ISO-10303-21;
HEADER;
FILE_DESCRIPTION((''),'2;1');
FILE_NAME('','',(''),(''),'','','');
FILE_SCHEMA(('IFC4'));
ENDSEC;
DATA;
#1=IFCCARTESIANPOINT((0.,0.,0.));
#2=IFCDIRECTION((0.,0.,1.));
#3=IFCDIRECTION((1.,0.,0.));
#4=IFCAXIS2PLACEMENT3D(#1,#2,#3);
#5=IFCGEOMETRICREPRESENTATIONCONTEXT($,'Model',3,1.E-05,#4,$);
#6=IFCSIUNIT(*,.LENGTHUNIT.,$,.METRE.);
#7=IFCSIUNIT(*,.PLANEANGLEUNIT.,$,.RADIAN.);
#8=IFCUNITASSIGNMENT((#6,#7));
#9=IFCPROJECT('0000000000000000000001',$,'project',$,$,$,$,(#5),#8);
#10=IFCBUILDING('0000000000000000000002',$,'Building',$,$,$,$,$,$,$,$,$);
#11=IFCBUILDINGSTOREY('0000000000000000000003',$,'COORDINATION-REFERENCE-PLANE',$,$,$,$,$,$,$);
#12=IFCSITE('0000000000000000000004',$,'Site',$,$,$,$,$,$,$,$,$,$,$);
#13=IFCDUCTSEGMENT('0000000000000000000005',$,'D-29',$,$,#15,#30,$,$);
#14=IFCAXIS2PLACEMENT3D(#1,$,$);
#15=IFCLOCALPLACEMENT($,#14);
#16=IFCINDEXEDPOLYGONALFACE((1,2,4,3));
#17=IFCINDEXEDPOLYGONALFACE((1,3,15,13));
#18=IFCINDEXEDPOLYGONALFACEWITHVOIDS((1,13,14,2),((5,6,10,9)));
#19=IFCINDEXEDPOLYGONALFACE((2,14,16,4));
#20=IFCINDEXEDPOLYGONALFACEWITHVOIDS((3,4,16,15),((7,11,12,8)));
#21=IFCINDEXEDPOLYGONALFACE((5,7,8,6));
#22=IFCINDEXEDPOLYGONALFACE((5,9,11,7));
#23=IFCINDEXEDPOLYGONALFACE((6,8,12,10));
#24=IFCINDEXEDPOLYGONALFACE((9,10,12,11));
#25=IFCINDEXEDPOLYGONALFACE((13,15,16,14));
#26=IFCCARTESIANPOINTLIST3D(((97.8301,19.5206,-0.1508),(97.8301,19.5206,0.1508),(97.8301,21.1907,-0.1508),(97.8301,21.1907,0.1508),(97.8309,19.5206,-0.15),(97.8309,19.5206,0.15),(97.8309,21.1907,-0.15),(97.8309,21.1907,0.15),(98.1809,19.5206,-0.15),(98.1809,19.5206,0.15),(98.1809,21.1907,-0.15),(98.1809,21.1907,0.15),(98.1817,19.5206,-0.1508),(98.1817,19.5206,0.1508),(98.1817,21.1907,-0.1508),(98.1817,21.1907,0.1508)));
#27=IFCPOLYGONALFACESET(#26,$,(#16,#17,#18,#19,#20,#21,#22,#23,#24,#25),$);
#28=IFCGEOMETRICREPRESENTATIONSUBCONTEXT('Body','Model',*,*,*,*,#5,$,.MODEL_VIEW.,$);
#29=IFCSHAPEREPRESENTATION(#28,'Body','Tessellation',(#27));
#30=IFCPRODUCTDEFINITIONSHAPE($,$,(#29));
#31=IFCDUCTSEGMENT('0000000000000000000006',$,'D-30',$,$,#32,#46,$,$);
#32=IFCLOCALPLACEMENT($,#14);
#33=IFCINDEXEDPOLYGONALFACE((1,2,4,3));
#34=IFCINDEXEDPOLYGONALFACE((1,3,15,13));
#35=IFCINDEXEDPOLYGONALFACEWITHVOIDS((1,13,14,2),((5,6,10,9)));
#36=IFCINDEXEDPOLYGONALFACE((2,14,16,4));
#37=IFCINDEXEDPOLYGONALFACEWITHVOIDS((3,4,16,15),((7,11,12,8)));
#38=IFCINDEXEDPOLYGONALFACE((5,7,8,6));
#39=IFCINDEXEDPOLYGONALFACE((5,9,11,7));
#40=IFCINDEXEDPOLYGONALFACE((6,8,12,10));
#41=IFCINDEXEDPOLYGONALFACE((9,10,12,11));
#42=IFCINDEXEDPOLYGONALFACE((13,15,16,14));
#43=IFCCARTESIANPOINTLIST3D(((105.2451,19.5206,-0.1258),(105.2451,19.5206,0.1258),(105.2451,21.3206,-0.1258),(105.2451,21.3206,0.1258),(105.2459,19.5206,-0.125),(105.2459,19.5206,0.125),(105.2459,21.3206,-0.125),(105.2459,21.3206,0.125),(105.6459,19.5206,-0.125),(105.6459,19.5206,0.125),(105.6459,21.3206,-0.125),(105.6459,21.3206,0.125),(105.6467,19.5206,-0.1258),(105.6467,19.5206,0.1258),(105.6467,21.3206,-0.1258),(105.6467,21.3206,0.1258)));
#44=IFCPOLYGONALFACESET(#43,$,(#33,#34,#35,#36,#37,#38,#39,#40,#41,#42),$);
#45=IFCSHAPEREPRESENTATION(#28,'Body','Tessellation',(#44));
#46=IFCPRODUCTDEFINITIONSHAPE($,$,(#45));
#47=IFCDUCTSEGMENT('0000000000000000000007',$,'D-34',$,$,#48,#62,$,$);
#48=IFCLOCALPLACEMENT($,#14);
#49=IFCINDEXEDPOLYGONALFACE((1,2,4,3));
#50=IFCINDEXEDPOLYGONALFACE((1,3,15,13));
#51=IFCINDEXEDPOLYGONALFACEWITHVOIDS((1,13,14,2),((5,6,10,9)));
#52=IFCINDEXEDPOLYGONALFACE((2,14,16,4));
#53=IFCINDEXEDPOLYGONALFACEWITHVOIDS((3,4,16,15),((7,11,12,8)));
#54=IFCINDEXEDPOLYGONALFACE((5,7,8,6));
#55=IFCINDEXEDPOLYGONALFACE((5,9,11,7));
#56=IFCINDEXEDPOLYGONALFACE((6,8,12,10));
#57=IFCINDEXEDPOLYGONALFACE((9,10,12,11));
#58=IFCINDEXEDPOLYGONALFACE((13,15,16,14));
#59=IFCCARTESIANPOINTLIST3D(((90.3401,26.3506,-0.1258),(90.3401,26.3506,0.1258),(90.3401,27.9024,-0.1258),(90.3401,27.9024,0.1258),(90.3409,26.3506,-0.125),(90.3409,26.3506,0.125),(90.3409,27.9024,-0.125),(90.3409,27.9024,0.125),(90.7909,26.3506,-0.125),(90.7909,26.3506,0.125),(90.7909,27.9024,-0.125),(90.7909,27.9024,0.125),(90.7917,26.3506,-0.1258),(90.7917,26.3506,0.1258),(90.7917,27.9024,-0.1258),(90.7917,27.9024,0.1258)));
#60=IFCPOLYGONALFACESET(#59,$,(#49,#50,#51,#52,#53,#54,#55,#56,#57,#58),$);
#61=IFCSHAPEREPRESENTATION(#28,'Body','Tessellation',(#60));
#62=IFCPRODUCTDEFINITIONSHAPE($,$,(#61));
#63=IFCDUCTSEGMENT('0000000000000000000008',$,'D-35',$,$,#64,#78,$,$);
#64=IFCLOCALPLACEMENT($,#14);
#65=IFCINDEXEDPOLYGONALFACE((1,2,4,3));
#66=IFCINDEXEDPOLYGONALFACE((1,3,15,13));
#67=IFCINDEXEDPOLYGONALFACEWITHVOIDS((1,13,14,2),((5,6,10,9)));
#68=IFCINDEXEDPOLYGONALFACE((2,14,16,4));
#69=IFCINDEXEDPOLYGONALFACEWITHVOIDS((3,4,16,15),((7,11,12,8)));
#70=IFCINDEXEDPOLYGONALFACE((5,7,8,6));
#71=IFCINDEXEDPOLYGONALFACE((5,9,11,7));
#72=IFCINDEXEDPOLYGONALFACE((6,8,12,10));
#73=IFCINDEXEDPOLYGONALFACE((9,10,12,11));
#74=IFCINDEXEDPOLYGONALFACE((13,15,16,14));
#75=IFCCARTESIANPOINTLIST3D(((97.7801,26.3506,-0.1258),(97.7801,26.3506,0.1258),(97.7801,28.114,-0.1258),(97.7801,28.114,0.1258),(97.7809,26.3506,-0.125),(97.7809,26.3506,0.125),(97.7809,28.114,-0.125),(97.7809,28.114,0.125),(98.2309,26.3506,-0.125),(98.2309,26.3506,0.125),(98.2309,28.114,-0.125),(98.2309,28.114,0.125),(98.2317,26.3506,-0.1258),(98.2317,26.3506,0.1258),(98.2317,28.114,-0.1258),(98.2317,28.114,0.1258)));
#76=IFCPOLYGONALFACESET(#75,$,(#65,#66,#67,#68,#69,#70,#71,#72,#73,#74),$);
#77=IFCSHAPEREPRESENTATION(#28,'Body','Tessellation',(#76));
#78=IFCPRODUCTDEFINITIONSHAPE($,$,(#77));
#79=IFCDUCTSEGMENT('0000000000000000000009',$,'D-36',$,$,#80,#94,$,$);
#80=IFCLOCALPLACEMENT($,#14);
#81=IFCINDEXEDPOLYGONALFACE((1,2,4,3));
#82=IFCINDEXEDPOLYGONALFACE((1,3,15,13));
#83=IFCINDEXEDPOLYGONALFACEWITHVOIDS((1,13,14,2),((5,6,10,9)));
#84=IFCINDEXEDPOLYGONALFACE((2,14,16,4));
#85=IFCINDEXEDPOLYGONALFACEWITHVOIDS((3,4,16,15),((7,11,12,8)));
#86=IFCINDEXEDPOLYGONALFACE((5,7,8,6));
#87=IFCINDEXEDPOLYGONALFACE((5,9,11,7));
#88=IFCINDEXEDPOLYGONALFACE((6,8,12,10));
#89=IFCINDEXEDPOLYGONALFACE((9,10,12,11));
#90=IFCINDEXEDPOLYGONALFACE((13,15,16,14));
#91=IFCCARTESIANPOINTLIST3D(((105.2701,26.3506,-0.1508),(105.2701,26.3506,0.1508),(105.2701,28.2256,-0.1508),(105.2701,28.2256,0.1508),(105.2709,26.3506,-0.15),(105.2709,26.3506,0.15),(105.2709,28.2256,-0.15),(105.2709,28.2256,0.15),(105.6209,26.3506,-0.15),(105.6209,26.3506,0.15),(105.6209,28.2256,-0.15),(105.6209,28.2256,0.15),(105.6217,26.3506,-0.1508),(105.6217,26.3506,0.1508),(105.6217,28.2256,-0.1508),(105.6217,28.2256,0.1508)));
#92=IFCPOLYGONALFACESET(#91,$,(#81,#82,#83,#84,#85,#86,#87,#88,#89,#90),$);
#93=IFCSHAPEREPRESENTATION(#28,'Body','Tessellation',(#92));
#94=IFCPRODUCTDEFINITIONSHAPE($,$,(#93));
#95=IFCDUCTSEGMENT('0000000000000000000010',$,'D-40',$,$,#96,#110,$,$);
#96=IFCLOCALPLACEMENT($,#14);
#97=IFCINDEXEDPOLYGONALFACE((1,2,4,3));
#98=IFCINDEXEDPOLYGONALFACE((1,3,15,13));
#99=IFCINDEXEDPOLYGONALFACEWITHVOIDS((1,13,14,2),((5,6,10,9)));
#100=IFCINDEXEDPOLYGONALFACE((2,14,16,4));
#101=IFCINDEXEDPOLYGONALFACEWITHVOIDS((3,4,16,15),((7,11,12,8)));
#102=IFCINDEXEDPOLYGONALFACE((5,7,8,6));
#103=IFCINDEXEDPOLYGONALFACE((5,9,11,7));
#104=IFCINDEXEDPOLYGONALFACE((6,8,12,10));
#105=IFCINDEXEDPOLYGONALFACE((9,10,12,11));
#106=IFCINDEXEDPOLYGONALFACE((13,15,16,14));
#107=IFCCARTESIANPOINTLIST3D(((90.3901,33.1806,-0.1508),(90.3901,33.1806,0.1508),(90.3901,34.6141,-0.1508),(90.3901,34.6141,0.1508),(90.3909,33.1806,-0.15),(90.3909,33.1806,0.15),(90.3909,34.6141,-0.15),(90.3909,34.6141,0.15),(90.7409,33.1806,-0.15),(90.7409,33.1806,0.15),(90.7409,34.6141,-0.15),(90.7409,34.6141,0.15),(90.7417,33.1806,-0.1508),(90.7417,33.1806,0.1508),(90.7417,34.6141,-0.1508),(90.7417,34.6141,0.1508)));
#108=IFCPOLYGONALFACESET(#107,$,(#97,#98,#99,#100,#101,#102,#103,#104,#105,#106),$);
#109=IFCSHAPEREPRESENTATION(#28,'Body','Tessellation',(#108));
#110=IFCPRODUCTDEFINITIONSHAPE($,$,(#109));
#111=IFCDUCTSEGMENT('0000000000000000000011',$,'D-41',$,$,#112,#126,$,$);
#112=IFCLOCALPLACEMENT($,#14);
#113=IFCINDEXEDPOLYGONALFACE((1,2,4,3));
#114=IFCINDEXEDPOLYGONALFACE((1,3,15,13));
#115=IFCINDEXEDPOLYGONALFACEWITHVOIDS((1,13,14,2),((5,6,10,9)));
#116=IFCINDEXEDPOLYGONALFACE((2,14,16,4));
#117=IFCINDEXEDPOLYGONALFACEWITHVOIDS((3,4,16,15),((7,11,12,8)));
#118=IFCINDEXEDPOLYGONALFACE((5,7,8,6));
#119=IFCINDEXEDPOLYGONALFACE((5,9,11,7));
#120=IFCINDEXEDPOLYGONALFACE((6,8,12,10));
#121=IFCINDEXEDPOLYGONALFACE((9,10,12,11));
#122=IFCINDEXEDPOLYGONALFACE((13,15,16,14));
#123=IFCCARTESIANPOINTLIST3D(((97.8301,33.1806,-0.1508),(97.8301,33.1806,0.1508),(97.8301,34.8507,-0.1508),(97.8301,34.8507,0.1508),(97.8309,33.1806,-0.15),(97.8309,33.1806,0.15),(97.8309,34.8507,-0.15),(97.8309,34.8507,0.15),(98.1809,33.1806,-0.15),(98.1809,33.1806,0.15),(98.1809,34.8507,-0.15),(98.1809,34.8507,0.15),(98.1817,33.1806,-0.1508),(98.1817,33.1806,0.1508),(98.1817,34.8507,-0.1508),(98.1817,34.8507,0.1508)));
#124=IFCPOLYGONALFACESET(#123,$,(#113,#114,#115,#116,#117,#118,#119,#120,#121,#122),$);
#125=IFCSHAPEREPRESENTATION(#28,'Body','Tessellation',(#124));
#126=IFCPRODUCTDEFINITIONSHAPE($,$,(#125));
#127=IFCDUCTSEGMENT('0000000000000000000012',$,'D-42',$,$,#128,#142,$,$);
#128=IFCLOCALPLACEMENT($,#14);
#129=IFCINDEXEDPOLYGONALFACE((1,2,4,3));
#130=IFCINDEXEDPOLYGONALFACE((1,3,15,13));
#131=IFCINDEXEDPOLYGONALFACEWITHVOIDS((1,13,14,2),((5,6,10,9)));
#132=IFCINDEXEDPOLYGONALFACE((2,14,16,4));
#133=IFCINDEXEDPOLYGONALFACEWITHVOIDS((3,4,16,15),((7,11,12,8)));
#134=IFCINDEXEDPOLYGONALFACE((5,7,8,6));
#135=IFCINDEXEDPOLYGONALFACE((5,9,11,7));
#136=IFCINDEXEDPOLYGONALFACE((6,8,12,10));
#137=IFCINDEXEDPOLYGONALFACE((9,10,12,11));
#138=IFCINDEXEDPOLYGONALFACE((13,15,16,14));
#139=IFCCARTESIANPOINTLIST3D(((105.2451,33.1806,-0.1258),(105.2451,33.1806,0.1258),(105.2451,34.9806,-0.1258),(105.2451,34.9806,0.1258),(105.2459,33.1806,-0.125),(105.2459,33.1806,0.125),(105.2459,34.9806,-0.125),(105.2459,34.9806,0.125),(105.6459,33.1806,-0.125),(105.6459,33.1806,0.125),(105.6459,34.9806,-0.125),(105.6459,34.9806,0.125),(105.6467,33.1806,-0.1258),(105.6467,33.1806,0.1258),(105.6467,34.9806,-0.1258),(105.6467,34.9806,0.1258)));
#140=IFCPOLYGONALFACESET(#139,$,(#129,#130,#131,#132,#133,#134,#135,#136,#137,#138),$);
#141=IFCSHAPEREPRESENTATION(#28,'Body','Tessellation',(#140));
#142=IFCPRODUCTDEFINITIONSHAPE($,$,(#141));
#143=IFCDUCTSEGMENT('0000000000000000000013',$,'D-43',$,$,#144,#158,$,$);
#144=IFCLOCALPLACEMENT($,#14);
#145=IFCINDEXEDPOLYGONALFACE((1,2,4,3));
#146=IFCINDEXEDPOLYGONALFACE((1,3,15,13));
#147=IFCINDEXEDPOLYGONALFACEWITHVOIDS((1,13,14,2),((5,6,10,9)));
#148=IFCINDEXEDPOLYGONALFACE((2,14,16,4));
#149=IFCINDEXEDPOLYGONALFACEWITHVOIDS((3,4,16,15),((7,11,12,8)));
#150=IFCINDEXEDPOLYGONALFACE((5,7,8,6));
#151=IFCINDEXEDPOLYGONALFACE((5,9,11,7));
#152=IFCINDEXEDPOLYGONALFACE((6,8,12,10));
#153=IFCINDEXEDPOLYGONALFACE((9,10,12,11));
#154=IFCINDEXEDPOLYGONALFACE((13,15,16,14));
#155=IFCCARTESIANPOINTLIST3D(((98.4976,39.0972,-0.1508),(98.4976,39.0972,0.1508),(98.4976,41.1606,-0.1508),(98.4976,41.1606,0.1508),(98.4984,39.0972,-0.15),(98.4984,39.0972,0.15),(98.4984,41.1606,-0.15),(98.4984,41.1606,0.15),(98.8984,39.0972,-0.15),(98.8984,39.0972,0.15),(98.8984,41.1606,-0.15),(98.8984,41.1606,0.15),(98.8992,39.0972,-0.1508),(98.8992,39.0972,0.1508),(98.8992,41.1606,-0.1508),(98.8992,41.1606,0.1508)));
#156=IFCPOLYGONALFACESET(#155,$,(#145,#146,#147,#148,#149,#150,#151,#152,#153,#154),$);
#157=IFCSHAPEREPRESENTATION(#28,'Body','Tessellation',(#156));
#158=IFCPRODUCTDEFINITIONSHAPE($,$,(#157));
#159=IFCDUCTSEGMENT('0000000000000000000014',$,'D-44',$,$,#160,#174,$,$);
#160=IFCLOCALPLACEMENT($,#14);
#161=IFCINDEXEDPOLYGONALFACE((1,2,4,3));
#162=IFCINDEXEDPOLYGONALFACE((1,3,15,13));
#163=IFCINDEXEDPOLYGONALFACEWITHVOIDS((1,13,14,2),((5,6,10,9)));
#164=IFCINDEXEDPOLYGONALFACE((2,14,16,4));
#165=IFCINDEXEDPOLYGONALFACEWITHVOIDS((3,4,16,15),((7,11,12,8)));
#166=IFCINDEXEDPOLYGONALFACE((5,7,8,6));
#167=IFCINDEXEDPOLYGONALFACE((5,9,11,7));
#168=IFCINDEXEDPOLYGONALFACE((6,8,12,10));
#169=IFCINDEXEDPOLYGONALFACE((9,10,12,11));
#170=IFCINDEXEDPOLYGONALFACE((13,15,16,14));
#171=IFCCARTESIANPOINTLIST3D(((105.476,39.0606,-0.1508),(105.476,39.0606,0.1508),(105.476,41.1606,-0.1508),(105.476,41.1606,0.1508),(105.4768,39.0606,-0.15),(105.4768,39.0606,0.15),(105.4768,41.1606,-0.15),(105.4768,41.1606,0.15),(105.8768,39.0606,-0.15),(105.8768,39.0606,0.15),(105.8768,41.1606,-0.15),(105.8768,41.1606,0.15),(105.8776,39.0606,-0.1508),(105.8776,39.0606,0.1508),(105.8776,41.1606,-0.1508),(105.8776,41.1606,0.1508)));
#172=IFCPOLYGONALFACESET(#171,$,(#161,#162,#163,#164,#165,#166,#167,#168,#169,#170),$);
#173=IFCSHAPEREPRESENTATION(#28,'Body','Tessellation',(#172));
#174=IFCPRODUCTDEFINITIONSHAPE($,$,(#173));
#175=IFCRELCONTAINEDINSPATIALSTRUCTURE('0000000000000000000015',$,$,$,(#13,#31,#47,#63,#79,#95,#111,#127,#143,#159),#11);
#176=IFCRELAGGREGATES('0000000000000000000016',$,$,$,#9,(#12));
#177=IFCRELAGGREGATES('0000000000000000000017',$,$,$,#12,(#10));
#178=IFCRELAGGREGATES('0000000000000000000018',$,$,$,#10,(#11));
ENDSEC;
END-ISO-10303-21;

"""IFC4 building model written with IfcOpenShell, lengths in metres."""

from ifc_helpers import new_model, si_unit, frame, origin, origin_with_axes, place, context, subcontext, project, spatial, hollow_rectangle, extrude, element, save


model = new_model("IFC4")

# Units and contexts
model_context = context("Model", 3, precision=1e-05, world=origin_with_axes())
body_context = subcontext(model_context, "Body", "Model", "MODEL_VIEW")
ifc_project = project(units=[si_unit("LENGTHUNIT", "METRE"), si_unit("PLANEANGLEUNIT", "RADIAN")], contexts=[model_context])

# Site, building, storey
site = spatial("IfcSite", under=ifc_project, Name="Site")
building = spatial("IfcBuilding", under=site, Name="Building")
storey = spatial("IfcBuildingStorey", under=building, Name="COORDINATION-REFERENCE-PLANE")

# Duct segments
duct_segment_1_placement = place(None, frame((98.0059, 19.5206, 0.0), z_axis=(0.0, 1.0, 0.0), x_axis=(1.0, 0.0, 0.0)))
element("IfcDuctSegment", 1, at=duct_segment_1_placement, inside=storey, Name="D-29", context=body_context, shape_type="SweptSolid", body=[
    extrude(hollow_rectangle(XDim=0.3516, YDim=0.3016, WallThickness=0.0008), origin(), (0.0, 0.0, 1.0), 1.6701),
])
duct_segment_2_placement = place(None, frame((105.4459, 19.5206, 0.0), z_axis=(0.0, 1.0, 0.0), x_axis=(1.0, 0.0, 0.0)))
element("IfcDuctSegment", 2, at=duct_segment_2_placement, inside=storey, Name="D-30", context=body_context, shape_type="SweptSolid", body=[
    extrude(hollow_rectangle(XDim=0.4016, YDim=0.2516, WallThickness=0.0008), origin(), (0.0, 0.0, 1.0), 1.8),
])
duct_segment_3_placement = place(None, frame((90.5659, 26.3506, 0.0), z_axis=(0.0, 1.0, 0.0), x_axis=(1.0, 0.0, 0.0)))
element("IfcDuctSegment", 3, at=duct_segment_3_placement, inside=storey, Name="D-34", context=body_context, shape_type="SweptSolid", body=[
    extrude(hollow_rectangle(XDim=0.4516, YDim=0.2516, WallThickness=0.0008), origin(), (0.0, 0.0, 1.0), 1.5518),
])
duct_segment_4_placement = place(None, frame((98.0059, 26.3506, 0.0), z_axis=(0.0, 1.0, 0.0), x_axis=(1.0, 0.0, 0.0)))
element("IfcDuctSegment", 4, at=duct_segment_4_placement, inside=storey, Name="D-35", context=body_context, shape_type="SweptSolid", body=[
    extrude(hollow_rectangle(XDim=0.4516, YDim=0.2516, WallThickness=0.0008), origin(), (0.0, 0.0, 1.0), 1.7634),
])
duct_segment_5_placement = place(None, frame((105.4459, 26.3506, 0.0), z_axis=(0.0, 1.0, 0.0), x_axis=(1.0, 0.0, 0.0)))
element("IfcDuctSegment", 5, at=duct_segment_5_placement, inside=storey, Name="D-36", context=body_context, shape_type="SweptSolid", body=[
    extrude(hollow_rectangle(XDim=0.3516, YDim=0.3016, WallThickness=0.0008), origin(), (0.0, 0.0, 1.0), 1.875),
])
duct_segment_6_placement = place(None, frame((90.5659, 33.1806, 0.0), z_axis=(0.0, 1.0, 0.0), x_axis=(1.0, 0.0, 0.0)))
element("IfcDuctSegment", 6, at=duct_segment_6_placement, inside=storey, Name="D-40", context=body_context, shape_type="SweptSolid", body=[
    extrude(hollow_rectangle(XDim=0.3516, YDim=0.3016, WallThickness=0.0008), origin(), (0.0, 0.0, 1.0), 1.4335),
])
duct_segment_7_placement = place(None, frame((98.0059, 33.1806, 0.0), z_axis=(0.0, 1.0, 0.0), x_axis=(1.0, 0.0, 0.0)))
element("IfcDuctSegment", 7, at=duct_segment_7_placement, inside=storey, Name="D-41", context=body_context, shape_type="SweptSolid", body=[
    extrude(hollow_rectangle(XDim=0.3516, YDim=0.3016, WallThickness=0.0008), origin(), (0.0, 0.0, 1.0), 1.6701),
])
duct_segment_8_placement = place(None, frame((105.4459, 33.1806, 0.0), z_axis=(0.0, 1.0, 0.0), x_axis=(1.0, 0.0, 0.0)))
element("IfcDuctSegment", 8, at=duct_segment_8_placement, inside=storey, Name="D-42", context=body_context, shape_type="SweptSolid", body=[
    extrude(hollow_rectangle(XDim=0.4016, YDim=0.2516, WallThickness=0.0008), origin(), (0.0, 0.0, 1.0), 1.8),
])
duct_segment_9_placement = place(None, frame((98.6984, 39.0972, 0.0), z_axis=(0.0, 1.0, 0.0), x_axis=(1.0, 0.0, 0.0)))
element("IfcDuctSegment", 9, at=duct_segment_9_placement, inside=storey, Name="D-43", context=body_context, shape_type="SweptSolid", body=[
    extrude(hollow_rectangle(XDim=0.4016, YDim=0.3016, WallThickness=0.0008), origin(), (0.0, 0.0, 1.0), 2.0634),
])
duct_segment_10_placement = place(None, frame((105.6768, 39.0606, 0.0), z_axis=(0.0, 1.0, 0.0), x_axis=(1.0, 0.0, 0.0)))
element("IfcDuctSegment", 10, at=duct_segment_10_placement, inside=storey, Name="D-44", context=body_context, shape_type="SweptSolid", body=[
    extrude(hollow_rectangle(XDim=0.4016, YDim=0.3016, WallThickness=0.0008), origin(), (0.0, 0.0, 1.0), 2.1),
])

save(model, "model.ifc")
